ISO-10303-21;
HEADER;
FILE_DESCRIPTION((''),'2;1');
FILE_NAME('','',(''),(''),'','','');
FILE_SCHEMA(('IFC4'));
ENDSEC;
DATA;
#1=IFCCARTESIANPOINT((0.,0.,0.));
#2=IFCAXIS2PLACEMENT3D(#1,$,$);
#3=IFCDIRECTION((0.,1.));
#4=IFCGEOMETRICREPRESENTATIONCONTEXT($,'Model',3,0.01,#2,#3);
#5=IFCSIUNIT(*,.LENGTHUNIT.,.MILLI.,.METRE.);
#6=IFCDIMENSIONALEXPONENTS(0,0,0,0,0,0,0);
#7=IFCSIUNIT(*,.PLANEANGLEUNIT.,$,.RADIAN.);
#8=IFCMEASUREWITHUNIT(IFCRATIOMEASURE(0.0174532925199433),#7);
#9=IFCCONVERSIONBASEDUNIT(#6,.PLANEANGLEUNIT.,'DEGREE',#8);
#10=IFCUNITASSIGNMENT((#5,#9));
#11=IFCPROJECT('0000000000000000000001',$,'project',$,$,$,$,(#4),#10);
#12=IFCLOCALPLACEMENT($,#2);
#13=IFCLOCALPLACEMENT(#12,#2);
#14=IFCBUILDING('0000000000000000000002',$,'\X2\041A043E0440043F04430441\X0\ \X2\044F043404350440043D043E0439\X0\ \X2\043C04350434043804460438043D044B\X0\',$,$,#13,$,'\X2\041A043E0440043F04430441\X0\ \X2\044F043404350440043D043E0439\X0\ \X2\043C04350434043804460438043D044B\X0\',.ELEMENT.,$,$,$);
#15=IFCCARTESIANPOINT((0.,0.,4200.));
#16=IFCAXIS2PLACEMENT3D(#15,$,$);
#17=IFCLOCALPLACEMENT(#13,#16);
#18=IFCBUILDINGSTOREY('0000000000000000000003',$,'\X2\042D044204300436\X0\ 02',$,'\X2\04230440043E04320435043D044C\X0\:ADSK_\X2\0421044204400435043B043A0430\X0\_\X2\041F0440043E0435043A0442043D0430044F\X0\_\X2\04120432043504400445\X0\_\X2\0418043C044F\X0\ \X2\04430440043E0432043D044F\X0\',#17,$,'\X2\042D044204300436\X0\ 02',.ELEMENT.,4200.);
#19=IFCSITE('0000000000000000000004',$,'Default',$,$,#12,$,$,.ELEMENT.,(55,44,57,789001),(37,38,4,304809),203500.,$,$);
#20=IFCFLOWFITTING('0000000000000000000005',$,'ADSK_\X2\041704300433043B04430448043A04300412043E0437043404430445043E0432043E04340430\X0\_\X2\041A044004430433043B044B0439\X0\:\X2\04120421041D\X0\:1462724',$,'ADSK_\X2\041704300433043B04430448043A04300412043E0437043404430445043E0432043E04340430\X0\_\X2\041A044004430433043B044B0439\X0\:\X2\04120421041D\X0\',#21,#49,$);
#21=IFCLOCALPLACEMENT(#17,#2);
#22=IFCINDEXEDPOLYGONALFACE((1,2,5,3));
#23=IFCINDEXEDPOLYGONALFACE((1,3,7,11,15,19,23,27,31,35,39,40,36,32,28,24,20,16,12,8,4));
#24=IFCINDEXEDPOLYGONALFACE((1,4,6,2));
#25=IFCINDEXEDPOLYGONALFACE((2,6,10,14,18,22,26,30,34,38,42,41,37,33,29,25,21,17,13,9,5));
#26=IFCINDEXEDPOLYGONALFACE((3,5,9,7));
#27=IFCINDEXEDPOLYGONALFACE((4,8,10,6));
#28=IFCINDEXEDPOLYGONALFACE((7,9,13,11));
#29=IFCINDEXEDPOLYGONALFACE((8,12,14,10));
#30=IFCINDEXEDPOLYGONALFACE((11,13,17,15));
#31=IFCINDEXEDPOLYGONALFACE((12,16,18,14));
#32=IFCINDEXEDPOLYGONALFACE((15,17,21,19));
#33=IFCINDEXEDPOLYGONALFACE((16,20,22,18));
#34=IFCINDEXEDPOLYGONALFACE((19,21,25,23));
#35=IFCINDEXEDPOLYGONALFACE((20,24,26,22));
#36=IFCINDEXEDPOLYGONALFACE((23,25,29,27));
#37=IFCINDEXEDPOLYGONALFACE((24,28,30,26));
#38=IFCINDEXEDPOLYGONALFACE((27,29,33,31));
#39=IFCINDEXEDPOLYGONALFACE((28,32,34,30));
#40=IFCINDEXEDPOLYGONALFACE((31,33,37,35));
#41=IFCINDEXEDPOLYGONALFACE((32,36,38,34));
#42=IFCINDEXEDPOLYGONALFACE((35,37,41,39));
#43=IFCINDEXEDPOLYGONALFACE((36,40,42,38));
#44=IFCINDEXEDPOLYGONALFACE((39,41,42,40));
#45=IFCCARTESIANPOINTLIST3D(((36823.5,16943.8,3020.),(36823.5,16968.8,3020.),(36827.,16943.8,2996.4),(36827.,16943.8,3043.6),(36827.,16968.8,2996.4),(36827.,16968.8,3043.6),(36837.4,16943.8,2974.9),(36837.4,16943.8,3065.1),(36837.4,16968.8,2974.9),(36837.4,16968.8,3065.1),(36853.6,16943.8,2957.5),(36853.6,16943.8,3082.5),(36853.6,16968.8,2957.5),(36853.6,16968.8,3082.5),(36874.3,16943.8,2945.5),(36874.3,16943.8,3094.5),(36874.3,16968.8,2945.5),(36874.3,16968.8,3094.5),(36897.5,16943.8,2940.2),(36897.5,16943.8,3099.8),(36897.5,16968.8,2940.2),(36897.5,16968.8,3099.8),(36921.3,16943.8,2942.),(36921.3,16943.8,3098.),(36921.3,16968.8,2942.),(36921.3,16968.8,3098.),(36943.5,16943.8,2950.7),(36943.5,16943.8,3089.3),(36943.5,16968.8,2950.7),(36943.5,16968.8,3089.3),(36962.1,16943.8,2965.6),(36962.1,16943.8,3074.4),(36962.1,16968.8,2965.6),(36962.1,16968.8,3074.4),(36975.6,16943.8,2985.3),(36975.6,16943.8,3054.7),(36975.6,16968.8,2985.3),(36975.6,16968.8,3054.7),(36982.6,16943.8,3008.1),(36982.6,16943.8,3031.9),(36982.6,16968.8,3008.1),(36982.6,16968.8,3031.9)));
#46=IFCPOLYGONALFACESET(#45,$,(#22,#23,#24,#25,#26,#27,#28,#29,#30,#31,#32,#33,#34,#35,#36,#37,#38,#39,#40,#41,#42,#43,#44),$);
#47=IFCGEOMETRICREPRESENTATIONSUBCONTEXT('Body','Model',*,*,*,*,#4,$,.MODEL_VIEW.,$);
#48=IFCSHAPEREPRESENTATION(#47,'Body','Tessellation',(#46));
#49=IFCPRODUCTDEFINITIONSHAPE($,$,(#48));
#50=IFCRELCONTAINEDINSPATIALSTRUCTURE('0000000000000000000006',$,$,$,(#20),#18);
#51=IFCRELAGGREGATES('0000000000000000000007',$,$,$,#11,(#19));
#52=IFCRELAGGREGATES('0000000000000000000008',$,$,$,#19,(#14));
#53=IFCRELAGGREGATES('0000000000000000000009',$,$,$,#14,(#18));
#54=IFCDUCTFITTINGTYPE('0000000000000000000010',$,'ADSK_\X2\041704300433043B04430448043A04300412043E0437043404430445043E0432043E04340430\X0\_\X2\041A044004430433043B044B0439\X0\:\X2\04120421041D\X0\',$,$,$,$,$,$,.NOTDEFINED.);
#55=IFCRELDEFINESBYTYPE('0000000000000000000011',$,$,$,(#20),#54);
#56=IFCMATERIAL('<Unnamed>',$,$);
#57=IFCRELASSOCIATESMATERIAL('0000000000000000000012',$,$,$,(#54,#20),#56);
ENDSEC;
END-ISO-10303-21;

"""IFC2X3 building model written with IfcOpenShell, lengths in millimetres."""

from ifc_helpers import new_model, entity, si_unit, converted_unit, direction, frame, origin, origin_2d_with_axis, place, context, subcontext, project, spatial, circle, extrude, source, transform, mapped, material, type_object, type_shapes, element, save


model = new_model("IFC2X3")

# Units and contexts
model_context = context("Model", 3, precision=0.01, world=origin(), true_north=direction((0.0, 1.0)))
body_context = subcontext(model_context, "Body", "Model", "MODEL_VIEW")
ifc_project = project(units=[si_unit("LENGTHUNIT", "METRE", prefix="MILLI"), converted_unit("PLANEANGLEUNIT", "DEGREE", entity("IfcRatioMeasure", 0.0174532925199433), si_unit("PLANEANGLEUNIT", "RADIAN"), dimensions=[0, 0, 0, 0, 0, 0, 0])], contexts=[model_context])

# Site, building, storey
site_placement = place(None, origin())
site = spatial("IfcSite", under=ifc_project, at=site_placement, Name="Default", CompositionType="ELEMENT", RefLatitude=(55, 44, 57, 789001), RefLongitude=(37, 38, 4, 304809), RefElevation=203500.0)
building_placement = place(site_placement, origin())
building = spatial("IfcBuilding", under=site, at=building_placement, Name="Корпус ядерной медицины", LongName="Корпус ядерной медицины", CompositionType="ELEMENT")
storey_placement = place(building_placement, frame((0.0, 0.0, 4200.0)))
storey = spatial("IfcBuildingStorey", under=building, at=storey_placement, Name="Этаж 02", ObjectType="Уровень:ADSK_Стрелка_Проектная_Вверх_Имя уровня", LongName="Этаж 02", CompositionType="ELEMENT", Elevation=4200.0)

# Flow fitting
ifc_material = material(Name="<Unnamed>")
duct_fitting_type = type_object("IfcDuctFittingType", Name="ADSK_ЗаглушкаВоздуховода_Круглый:ВСН", PredefinedType="NOTDEFINED", material=ifc_material)
shared_shape = source(origin(), body_context, "Body", "SweptSolid", [
    extrude(circle(Radius=80.0, at=origin_2d_with_axis()), frame((0.0, 0.0, 0.0), z_axis=(1.0, 0.0, 0.0), x_axis=(0.0, 1.0, 0.0)), (0.0, 0.0, 1.0), 25.0),
])
type_shapes(duct_fitting_type, [shared_shape])
flow_fitting_placement = place(storey_placement, frame((36903.5, 16943.8, 3020.0), z_axis=(0.0, 0.0, 1.0), x_axis=(0.0, 1.0, 0.0)))
element("IfcFlowFitting", 1, at=flow_fitting_placement, inside=storey, type_object=duct_fitting_type, material=ifc_material, Name="ADSK_ЗаглушкаВоздуховода_Круглый:ВСН:1462724", ObjectType="ADSK_ЗаглушкаВоздуховода_Круглый:ВСН", context=body_context, shape_type="MappedRepresentation", body=[
    mapped(shared_shape, transform((0.0, 0.0, 0.0), scale=1.0)),
])

save(model, "model.ifc")
